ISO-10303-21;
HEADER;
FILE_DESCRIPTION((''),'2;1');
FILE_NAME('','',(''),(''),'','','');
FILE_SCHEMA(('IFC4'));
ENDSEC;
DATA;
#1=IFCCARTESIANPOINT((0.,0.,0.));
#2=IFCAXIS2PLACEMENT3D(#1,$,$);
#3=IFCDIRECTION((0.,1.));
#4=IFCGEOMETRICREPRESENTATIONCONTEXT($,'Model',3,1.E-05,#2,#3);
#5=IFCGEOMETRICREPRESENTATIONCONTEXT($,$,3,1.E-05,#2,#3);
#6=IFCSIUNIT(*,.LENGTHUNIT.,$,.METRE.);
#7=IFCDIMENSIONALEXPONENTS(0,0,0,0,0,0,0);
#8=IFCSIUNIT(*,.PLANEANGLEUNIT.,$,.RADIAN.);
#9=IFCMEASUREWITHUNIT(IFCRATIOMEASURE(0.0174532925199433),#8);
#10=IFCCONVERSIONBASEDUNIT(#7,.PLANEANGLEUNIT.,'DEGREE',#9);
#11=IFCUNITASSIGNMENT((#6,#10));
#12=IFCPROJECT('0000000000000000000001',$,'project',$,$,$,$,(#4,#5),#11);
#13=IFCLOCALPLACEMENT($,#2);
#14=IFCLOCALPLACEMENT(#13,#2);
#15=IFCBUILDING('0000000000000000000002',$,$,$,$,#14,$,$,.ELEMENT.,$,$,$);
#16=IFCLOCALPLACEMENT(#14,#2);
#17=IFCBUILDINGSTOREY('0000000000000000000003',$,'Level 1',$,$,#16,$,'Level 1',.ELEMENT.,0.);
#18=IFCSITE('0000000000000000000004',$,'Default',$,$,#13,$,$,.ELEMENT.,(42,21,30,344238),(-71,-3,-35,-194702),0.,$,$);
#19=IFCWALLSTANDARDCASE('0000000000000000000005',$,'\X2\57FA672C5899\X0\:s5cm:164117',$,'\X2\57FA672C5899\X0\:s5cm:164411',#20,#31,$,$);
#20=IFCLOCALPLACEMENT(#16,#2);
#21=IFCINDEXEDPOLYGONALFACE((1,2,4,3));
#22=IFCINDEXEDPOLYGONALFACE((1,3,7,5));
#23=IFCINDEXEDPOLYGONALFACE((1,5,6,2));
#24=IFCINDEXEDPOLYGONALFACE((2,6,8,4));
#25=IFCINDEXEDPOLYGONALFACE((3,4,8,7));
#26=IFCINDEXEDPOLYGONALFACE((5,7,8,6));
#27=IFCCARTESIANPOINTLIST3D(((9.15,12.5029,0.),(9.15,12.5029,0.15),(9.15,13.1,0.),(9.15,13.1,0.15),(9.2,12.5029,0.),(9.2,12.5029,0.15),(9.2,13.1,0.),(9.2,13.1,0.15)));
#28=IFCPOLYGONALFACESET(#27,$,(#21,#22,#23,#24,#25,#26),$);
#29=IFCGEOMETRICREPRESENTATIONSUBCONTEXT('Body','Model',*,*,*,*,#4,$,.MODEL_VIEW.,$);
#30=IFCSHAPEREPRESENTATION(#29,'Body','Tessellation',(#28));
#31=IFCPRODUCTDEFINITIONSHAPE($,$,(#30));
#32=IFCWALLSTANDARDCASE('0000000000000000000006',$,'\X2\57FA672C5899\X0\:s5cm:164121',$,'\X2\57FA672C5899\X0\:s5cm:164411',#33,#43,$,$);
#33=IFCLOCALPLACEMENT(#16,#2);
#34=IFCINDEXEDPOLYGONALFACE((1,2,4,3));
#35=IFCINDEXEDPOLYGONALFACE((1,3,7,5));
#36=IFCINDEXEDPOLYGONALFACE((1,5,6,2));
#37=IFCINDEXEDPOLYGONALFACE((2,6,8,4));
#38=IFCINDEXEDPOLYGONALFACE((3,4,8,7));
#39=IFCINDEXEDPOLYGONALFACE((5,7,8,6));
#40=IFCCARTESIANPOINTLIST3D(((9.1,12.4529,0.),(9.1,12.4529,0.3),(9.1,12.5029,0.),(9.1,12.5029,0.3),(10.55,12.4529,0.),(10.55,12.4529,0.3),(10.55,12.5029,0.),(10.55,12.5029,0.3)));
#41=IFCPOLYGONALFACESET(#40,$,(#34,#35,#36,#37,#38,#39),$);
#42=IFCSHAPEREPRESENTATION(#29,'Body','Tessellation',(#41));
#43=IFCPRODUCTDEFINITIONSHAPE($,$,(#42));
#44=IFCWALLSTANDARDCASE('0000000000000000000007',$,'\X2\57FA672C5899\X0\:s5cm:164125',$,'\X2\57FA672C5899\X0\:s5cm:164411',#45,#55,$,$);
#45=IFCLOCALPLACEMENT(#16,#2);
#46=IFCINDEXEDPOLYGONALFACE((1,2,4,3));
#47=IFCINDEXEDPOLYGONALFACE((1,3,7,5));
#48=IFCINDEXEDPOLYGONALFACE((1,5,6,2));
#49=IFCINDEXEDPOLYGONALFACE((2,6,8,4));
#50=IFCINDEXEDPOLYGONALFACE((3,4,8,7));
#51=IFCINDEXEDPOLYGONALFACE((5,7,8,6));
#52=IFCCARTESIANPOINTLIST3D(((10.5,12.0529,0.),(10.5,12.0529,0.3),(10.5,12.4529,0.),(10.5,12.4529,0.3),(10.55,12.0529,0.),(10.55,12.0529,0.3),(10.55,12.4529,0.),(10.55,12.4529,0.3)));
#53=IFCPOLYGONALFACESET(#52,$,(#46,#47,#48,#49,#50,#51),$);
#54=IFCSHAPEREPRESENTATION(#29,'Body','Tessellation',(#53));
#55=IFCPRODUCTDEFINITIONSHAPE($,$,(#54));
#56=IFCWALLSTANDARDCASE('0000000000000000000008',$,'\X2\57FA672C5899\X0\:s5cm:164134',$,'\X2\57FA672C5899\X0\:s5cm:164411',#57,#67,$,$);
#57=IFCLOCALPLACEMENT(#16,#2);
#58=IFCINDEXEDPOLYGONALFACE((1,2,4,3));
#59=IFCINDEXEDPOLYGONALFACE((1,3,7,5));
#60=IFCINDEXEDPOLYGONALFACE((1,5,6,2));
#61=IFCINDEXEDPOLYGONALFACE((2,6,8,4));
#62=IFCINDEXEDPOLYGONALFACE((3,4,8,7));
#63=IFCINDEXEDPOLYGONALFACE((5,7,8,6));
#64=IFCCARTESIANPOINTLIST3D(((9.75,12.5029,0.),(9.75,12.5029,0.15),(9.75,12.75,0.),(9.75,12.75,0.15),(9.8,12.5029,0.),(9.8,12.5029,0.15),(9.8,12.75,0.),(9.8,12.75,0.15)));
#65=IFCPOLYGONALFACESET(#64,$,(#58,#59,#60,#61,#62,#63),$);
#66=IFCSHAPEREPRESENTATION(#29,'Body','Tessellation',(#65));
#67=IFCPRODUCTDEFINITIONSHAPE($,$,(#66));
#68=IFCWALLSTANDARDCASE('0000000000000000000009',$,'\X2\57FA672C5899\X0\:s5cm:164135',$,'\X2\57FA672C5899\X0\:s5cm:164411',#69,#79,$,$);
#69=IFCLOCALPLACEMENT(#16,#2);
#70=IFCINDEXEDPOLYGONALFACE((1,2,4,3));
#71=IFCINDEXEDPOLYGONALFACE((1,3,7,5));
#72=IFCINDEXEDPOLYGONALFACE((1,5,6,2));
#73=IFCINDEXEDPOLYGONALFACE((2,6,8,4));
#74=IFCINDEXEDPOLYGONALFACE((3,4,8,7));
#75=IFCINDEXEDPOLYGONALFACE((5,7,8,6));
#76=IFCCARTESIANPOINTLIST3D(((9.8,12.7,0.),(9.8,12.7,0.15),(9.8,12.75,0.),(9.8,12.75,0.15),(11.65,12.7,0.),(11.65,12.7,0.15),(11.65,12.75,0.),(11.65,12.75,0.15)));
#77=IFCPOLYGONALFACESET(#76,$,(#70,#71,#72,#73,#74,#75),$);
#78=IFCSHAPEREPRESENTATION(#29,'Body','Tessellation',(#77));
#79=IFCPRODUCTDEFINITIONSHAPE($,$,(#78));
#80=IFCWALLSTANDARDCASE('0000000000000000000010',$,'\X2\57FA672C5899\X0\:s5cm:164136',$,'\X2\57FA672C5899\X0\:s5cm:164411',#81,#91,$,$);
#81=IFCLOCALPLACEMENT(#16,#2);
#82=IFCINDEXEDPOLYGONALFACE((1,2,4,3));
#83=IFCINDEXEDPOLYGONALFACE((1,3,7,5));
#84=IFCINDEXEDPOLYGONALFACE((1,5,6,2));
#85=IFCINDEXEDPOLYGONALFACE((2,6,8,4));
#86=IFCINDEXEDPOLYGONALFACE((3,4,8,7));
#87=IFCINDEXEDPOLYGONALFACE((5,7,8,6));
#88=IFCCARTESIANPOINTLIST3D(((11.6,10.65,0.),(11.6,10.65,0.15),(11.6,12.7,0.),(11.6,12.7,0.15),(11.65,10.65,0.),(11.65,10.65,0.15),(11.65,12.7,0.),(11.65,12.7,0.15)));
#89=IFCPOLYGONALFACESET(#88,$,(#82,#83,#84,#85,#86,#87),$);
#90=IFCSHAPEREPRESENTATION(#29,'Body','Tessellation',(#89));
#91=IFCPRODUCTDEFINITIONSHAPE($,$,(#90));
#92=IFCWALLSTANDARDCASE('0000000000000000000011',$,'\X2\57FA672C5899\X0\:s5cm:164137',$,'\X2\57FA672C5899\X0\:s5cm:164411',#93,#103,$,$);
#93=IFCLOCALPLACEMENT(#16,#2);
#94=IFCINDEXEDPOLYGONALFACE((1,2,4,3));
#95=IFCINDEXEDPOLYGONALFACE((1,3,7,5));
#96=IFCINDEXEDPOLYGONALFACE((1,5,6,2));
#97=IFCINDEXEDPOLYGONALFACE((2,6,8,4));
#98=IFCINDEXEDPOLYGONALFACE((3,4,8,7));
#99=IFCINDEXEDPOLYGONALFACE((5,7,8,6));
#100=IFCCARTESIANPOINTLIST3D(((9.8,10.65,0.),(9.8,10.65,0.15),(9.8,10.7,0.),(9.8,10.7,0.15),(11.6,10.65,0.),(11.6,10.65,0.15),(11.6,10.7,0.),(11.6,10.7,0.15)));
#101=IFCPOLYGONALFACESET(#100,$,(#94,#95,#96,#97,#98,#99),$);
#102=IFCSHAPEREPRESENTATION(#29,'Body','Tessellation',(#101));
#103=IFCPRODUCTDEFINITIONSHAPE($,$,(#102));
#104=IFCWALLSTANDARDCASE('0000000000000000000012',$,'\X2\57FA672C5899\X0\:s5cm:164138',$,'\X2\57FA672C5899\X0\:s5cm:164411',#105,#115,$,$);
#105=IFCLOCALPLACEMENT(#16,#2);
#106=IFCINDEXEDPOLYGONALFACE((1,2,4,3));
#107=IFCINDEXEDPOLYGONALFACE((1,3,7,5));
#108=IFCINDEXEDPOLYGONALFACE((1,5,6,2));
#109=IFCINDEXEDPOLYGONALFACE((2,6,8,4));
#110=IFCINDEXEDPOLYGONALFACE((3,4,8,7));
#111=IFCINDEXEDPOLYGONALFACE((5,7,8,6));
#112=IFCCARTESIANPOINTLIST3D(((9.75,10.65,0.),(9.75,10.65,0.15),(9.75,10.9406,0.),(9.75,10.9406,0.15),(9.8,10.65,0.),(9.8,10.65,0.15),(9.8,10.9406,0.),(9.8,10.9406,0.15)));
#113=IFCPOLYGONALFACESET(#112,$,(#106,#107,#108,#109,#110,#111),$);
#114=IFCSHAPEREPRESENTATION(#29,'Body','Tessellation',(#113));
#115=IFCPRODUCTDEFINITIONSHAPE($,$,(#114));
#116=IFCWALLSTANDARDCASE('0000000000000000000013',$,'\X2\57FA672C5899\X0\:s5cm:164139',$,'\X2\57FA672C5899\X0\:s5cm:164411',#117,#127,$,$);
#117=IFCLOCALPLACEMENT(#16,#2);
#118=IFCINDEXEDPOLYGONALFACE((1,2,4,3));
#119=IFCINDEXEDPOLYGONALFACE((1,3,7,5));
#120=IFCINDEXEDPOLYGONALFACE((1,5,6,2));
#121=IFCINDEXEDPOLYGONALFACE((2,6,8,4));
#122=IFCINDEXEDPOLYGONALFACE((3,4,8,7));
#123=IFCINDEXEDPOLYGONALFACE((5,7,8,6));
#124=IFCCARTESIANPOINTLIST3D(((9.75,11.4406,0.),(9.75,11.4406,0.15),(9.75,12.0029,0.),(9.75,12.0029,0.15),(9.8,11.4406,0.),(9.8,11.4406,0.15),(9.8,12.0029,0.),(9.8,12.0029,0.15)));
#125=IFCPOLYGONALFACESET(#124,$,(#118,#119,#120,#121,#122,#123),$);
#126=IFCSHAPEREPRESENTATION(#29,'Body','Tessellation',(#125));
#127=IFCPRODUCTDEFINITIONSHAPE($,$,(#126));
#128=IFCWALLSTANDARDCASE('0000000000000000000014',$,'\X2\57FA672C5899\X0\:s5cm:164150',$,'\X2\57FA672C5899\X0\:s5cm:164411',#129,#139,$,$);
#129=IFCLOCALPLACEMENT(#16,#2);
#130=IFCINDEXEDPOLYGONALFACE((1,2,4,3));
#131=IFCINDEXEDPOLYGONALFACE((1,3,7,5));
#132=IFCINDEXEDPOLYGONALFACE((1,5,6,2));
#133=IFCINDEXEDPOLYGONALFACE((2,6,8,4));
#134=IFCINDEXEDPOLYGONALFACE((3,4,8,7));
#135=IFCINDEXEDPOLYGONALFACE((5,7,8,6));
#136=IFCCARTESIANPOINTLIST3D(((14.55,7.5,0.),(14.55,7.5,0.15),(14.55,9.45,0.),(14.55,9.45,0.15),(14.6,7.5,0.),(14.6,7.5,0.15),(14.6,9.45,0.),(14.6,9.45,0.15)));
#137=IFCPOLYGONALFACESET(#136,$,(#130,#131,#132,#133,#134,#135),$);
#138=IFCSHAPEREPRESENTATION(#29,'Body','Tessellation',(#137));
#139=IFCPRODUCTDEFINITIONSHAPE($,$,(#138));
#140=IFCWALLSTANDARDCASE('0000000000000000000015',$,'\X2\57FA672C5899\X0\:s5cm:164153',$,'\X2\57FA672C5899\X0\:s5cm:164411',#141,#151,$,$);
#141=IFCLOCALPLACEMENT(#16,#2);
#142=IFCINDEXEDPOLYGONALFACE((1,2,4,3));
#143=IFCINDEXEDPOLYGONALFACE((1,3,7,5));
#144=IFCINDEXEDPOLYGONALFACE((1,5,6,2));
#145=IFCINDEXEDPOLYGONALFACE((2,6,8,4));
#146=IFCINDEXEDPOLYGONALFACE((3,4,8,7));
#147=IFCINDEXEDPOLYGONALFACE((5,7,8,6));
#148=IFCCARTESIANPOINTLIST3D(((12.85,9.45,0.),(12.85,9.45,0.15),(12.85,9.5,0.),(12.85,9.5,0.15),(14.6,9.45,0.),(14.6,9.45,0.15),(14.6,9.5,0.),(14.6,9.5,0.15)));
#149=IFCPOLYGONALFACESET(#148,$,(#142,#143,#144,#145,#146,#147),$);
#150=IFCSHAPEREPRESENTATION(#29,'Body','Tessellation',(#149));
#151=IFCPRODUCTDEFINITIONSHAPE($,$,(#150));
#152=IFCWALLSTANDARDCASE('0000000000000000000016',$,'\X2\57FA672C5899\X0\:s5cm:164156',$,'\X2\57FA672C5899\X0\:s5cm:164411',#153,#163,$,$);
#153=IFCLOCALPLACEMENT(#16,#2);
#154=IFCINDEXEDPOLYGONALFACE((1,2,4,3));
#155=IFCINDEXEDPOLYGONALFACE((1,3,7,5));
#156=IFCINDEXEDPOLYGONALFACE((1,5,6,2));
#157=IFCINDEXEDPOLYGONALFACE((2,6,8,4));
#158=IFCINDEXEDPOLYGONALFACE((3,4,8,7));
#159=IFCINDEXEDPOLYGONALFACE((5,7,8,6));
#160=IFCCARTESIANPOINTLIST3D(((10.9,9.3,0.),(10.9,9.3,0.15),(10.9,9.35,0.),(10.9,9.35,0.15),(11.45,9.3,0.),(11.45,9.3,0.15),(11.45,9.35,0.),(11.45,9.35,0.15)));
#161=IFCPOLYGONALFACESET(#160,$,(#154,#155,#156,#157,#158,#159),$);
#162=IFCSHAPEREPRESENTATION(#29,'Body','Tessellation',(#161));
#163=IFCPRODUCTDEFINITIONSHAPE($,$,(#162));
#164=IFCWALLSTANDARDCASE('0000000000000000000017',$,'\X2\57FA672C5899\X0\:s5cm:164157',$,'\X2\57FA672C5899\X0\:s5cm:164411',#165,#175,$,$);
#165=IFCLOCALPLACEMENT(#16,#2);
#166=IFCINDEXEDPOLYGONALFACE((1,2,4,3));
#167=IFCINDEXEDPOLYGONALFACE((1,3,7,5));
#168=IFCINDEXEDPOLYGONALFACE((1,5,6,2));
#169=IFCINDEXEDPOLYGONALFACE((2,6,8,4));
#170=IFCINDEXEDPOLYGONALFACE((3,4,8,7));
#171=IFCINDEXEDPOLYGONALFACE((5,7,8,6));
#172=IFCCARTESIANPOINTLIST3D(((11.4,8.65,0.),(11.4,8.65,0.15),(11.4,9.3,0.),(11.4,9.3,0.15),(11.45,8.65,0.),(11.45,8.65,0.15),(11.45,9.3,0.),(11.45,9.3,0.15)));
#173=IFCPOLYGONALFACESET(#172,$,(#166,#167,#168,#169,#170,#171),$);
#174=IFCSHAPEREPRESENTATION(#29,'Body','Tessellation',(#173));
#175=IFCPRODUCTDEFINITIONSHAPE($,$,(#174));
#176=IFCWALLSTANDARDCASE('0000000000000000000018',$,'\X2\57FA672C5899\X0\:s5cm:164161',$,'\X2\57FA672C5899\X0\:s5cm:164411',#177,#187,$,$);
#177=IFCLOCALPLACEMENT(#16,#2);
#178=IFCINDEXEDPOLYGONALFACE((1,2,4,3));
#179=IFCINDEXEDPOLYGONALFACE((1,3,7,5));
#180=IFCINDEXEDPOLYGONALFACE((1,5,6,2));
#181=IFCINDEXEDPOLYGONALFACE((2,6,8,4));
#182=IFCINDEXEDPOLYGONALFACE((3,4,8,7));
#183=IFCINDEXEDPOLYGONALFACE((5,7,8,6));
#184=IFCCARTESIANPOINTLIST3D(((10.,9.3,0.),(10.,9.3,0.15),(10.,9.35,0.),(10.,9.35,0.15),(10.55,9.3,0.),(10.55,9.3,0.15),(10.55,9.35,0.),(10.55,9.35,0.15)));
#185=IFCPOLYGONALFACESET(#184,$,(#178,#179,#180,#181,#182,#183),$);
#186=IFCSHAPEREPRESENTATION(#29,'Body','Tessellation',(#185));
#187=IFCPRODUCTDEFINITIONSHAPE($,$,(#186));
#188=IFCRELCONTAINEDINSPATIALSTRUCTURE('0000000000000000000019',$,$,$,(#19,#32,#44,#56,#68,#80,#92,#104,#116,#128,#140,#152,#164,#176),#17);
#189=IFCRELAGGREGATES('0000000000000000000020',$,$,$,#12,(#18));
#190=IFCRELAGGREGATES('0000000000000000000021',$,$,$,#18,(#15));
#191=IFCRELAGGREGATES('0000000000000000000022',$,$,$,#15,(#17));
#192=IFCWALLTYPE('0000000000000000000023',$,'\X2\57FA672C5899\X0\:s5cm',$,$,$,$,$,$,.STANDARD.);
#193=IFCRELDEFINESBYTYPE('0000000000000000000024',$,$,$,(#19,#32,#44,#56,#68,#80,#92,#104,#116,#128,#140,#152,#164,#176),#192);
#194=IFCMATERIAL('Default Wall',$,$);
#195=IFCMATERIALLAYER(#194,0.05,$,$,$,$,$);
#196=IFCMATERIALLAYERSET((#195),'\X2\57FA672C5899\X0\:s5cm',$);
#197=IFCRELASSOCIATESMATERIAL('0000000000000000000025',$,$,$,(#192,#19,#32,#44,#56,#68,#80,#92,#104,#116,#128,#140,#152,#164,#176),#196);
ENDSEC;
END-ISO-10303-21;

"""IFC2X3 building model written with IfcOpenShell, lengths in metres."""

from ifc_helpers import new_model, entity, si_unit, converted_unit, direction, frame, frame_2d, origin, place, context, subcontext, project, spatial, rectangle, extrude, material, layer, layer_set, layer_usage, type_object, element, save


model = new_model("IFC2X3")

# Units and contexts
model_context = context("Model", 3, precision=1e-05, world=origin(), true_north=direction((0.0, 1.0)))
context_of_model = context(None, 3, precision=1e-05, world=origin(), true_north=direction((0.0, 1.0)))
body_context = subcontext(model_context, "Body", "Model", "MODEL_VIEW")
ifc_project = project(units=[si_unit("LENGTHUNIT", "METRE"), converted_unit("PLANEANGLEUNIT", "DEGREE", entity("IfcRatioMeasure", 0.0174532925199433), si_unit("PLANEANGLEUNIT", "RADIAN"), dimensions=[0, 0, 0, 0, 0, 0, 0])], contexts=[model_context, context_of_model])

# Site, building, storey
site_placement = place(None, origin())
site = spatial("IfcSite", under=ifc_project, at=site_placement, Name="Default", CompositionType="ELEMENT", RefLatitude=(42, 21, 30, 344238), RefLongitude=(-71, -3, -35, -194702), RefElevation=0.0)
building_placement = place(site_placement, origin())
building = spatial("IfcBuilding", under=site, at=building_placement, CompositionType="ELEMENT")
storey_placement = place(building_placement, origin())
storey = spatial("IfcBuildingStorey", under=building, at=storey_placement, Name="Level 1", LongName="Level 1", CompositionType="ELEMENT", Elevation=0.0)

# Walls
ifc_material = material(Name="Default Wall")
ifc_layer = layer(ifc_material, 0.05)
ifc_layer_set = layer_set([ifc_layer], Name="基本墙:s5cm")
wall_type = type_object("IfcWallType", Name="基本墙:s5cm", PredefinedType="STANDARD", material=ifc_layer_set)
ifc_layer_usage_1 = layer_usage(ifc_layer_set, "AXIS2", "NEGATIVE", 0.025)
wall_1_placement = place(storey_placement, frame((9.175, 13.1, 0.0), z_axis=(0.0, 0.0, 1.0), x_axis=(0.0, -1.0, 0.0)))
element("IfcWallStandardCase", 1, at=wall_1_placement, inside=storey, type_object=wall_type, material=ifc_layer_usage_1, Name="基本墙:s5cm:164117", ObjectType="基本墙:s5cm:164411", context=body_context, shape_type="SweptSolid", body=[
    extrude(rectangle(XDim=0.5971, YDim=0.05, at=frame_2d((0.2986, 0.0), x_axis=(-1.0, 0.0))), origin(), (0.0, 0.0, 1.0), 0.15),
])
ifc_layer_usage_2 = layer_usage(ifc_layer_set, "AXIS2", "NEGATIVE", 0.025)
wall_2_placement = place(storey_placement, frame((9.1, 12.4779, 0.0)))
element("IfcWallStandardCase", 2, at=wall_2_placement, inside=storey, type_object=wall_type, material=ifc_layer_usage_2, Name="基本墙:s5cm:164121", ObjectType="基本墙:s5cm:164411", context=body_context, shape_type="SweptSolid", body=[
    extrude(rectangle(XDim=1.45, YDim=0.05, at=frame_2d((0.725, 0.0), x_axis=(-1.0, 0.0))), origin(), (0.0, 0.0, 1.0), 0.3),
])
ifc_layer_usage_3 = layer_usage(ifc_layer_set, "AXIS2", "NEGATIVE", 0.025)
wall_3_placement = place(storey_placement, frame((10.525, 12.4529, 0.0), z_axis=(0.0, 0.0, 1.0), x_axis=(0.0, -1.0, 0.0)))
element("IfcWallStandardCase", 3, at=wall_3_placement, inside=storey, type_object=wall_type, material=ifc_layer_usage_3, Name="基本墙:s5cm:164125", ObjectType="基本墙:s5cm:164411", context=body_context, shape_type="SweptSolid", body=[
    extrude(rectangle(XDim=0.4, YDim=0.05, at=frame_2d((0.2, 0.0), x_axis=(-1.0, 0.0))), origin(), (0.0, 0.0, 1.0), 0.3),
])
ifc_layer_usage_4 = layer_usage(ifc_layer_set, "AXIS2", "NEGATIVE", 0.025)
wall_4_placement = place(storey_placement, frame((9.775, 12.5029, 0.0), z_axis=(0.0, 0.0, 1.0), x_axis=(0.0, 1.0, 0.0)))
element("IfcWallStandardCase", 4, at=wall_4_placement, inside=storey, type_object=wall_type, material=ifc_layer_usage_4, Name="基本墙:s5cm:164134", ObjectType="基本墙:s5cm:164411", context=body_context, shape_type="SweptSolid", body=[
    extrude(rectangle(XDim=0.2471, YDim=0.05, at=frame_2d((0.1236, 0.0), x_axis=(-1.0, 0.0))), origin(), (0.0, 0.0, 1.0), 0.15),
])
ifc_layer_usage_5 = layer_usage(ifc_layer_set, "AXIS2", "NEGATIVE", 0.025)
wall_5_placement = place(storey_placement, frame((9.8, 12.725, 0.0)))
element("IfcWallStandardCase", 5, at=wall_5_placement, inside=storey, type_object=wall_type, material=ifc_layer_usage_5, Name="基本墙:s5cm:164135", ObjectType="基本墙:s5cm:164411", context=body_context, shape_type="SweptSolid", body=[
    extrude(rectangle(XDim=1.85, YDim=0.05, at=frame_2d((0.925, 0.0), x_axis=(-1.0, 0.0))), origin(), (0.0, 0.0, 1.0), 0.15),
])
ifc_layer_usage_6 = layer_usage(ifc_layer_set, "AXIS2", "NEGATIVE", 0.025)
wall_6_placement = place(storey_placement, frame((11.625, 12.7, 0.0), z_axis=(0.0, 0.0, 1.0), x_axis=(0.0, -1.0, 0.0)))
element("IfcWallStandardCase", 6, at=wall_6_placement, inside=storey, type_object=wall_type, material=ifc_layer_usage_6, Name="基本墙:s5cm:164136", ObjectType="基本墙:s5cm:164411", context=body_context, shape_type="SweptSolid", body=[
    extrude(rectangle(XDim=2.05, YDim=0.05, at=frame_2d((1.025, 0.0), x_axis=(-1.0, 0.0))), origin(), (0.0, 0.0, 1.0), 0.15),
])
ifc_layer_usage_7 = layer_usage(ifc_layer_set, "AXIS2", "NEGATIVE", 0.025)
wall_7_placement = place(storey_placement, frame((11.6, 10.675, 0.0), z_axis=(0.0, 0.0, 1.0), x_axis=(-1.0, 0.0, 0.0)))
element("IfcWallStandardCase", 7, at=wall_7_placement, inside=storey, type_object=wall_type, material=ifc_layer_usage_7, Name="基本墙:s5cm:164137", ObjectType="基本墙:s5cm:164411", context=body_context, shape_type="SweptSolid", body=[
    extrude(rectangle(XDim=1.8, YDim=0.05, at=frame_2d((0.9, 0.0), x_axis=(-1.0, 0.0))), origin(), (0.0, 0.0, 1.0), 0.15),
])
ifc_layer_usage_8 = layer_usage(ifc_layer_set, "AXIS2", "NEGATIVE", 0.025)
wall_8_placement = place(storey_placement, frame((9.775, 10.65, 0.0), z_axis=(0.0, 0.0, 1.0), x_axis=(0.0, 1.0, 0.0)))
element("IfcWallStandardCase", 8, at=wall_8_placement, inside=storey, type_object=wall_type, material=ifc_layer_usage_8, Name="基本墙:s5cm:164138", ObjectType="基本墙:s5cm:164411", context=body_context, shape_type="SweptSolid", body=[
    extrude(rectangle(XDim=0.2906, YDim=0.05, at=frame_2d((0.1453, 0.0), x_axis=(-1.0, 0.0))), origin(), (0.0, 0.0, 1.0), 0.15),
])
ifc_layer_usage_9 = layer_usage(ifc_layer_set, "AXIS2", "NEGATIVE", 0.025)
wall_9_placement = place(storey_placement, frame((9.775, 11.4406, 0.0), z_axis=(0.0, 0.0, 1.0), x_axis=(0.0, 1.0, 0.0)))
element("IfcWallStandardCase", 9, at=wall_9_placement, inside=storey, type_object=wall_type, material=ifc_layer_usage_9, Name="基本墙:s5cm:164139", ObjectType="基本墙:s5cm:164411", context=body_context, shape_type="SweptSolid", body=[
    extrude(rectangle(XDim=0.5623, YDim=0.05, at=frame_2d((0.2811, 0.0), x_axis=(-1.0, 0.0))), origin(), (0.0, 0.0, 1.0), 0.15),
])
ifc_layer_usage_10 = layer_usage(ifc_layer_set, "AXIS2", "NEGATIVE", 0.025)
wall_10_placement = place(storey_placement, frame((14.575, 9.45, 0.0), z_axis=(0.0, 0.0, 1.0), x_axis=(0.0, -1.0, 0.0)))
element("IfcWallStandardCase", 10, at=wall_10_placement, inside=storey, type_object=wall_type, material=ifc_layer_usage_10, Name="基本墙:s5cm:164150", ObjectType="基本墙:s5cm:164411", context=body_context, shape_type="SweptSolid", body=[
    extrude(rectangle(XDim=1.95, YDim=0.05, at=frame_2d((0.975, 0.0), x_axis=(-1.0, 0.0))), origin(), (0.0, 0.0, 1.0), 0.15),
])
ifc_layer_usage_11 = layer_usage(ifc_layer_set, "AXIS2", "NEGATIVE", 0.025)
wall_11_placement = place(storey_placement, frame((12.85, 9.475, 0.0)))
element("IfcWallStandardCase", 11, at=wall_11_placement, inside=storey, type_object=wall_type, material=ifc_layer_usage_11, Name="基本墙:s5cm:164153", ObjectType="基本墙:s5cm:164411", context=body_context, shape_type="SweptSolid", body=[
    extrude(rectangle(XDim=1.75, YDim=0.05, at=frame_2d((0.875, 0.0), x_axis=(-1.0, 0.0))), origin(), (0.0, 0.0, 1.0), 0.15),
])
ifc_layer_usage_12 = layer_usage(ifc_layer_set, "AXIS2", "NEGATIVE", 0.025)
wall_12_placement = place(storey_placement, frame((10.9, 9.325, 0.0)))
element("IfcWallStandardCase", 12, at=wall_12_placement, inside=storey, type_object=wall_type, material=ifc_layer_usage_12, Name="基本墙:s5cm:164156", ObjectType="基本墙:s5cm:164411", context=body_context, shape_type="SweptSolid", body=[
    extrude(rectangle(XDim=0.55, YDim=0.05, at=frame_2d((0.275, 0.0), x_axis=(-1.0, 0.0))), origin(), (0.0, 0.0, 1.0), 0.15),
])
ifc_layer_usage_13 = layer_usage(ifc_layer_set, "AXIS2", "NEGATIVE", 0.025)
wall_13_placement = place(storey_placement, frame((11.425, 9.3, 0.0), z_axis=(0.0, 0.0, 1.0), x_axis=(0.0, -1.0, 0.0)))
element("IfcWallStandardCase", 13, at=wall_13_placement, inside=storey, type_object=wall_type, material=ifc_layer_usage_13, Name="基本墙:s5cm:164157", ObjectType="基本墙:s5cm:164411", context=body_context, shape_type="SweptSolid", body=[
    extrude(rectangle(XDim=0.65, YDim=0.05, at=frame_2d((0.325, 0.0), x_axis=(-1.0, 0.0))), origin(), (0.0, 0.0, 1.0), 0.15),
])
ifc_layer_usage_14 = layer_usage(ifc_layer_set, "AXIS2", "NEGATIVE", 0.025)
wall_14_placement = place(storey_placement, frame((10.0, 9.325, 0.0)))
element("IfcWallStandardCase", 14, at=wall_14_placement, inside=storey, type_object=wall_type, material=ifc_layer_usage_14, Name="基本墙:s5cm:164161", ObjectType="基本墙:s5cm:164411", context=body_context, shape_type="SweptSolid", body=[
    extrude(rectangle(XDim=0.55, YDim=0.05, at=frame_2d((0.275, 0.0), x_axis=(-1.0, 0.0))), origin(), (0.0, 0.0, 1.0), 0.15),
])

save(model, "model.ifc")
